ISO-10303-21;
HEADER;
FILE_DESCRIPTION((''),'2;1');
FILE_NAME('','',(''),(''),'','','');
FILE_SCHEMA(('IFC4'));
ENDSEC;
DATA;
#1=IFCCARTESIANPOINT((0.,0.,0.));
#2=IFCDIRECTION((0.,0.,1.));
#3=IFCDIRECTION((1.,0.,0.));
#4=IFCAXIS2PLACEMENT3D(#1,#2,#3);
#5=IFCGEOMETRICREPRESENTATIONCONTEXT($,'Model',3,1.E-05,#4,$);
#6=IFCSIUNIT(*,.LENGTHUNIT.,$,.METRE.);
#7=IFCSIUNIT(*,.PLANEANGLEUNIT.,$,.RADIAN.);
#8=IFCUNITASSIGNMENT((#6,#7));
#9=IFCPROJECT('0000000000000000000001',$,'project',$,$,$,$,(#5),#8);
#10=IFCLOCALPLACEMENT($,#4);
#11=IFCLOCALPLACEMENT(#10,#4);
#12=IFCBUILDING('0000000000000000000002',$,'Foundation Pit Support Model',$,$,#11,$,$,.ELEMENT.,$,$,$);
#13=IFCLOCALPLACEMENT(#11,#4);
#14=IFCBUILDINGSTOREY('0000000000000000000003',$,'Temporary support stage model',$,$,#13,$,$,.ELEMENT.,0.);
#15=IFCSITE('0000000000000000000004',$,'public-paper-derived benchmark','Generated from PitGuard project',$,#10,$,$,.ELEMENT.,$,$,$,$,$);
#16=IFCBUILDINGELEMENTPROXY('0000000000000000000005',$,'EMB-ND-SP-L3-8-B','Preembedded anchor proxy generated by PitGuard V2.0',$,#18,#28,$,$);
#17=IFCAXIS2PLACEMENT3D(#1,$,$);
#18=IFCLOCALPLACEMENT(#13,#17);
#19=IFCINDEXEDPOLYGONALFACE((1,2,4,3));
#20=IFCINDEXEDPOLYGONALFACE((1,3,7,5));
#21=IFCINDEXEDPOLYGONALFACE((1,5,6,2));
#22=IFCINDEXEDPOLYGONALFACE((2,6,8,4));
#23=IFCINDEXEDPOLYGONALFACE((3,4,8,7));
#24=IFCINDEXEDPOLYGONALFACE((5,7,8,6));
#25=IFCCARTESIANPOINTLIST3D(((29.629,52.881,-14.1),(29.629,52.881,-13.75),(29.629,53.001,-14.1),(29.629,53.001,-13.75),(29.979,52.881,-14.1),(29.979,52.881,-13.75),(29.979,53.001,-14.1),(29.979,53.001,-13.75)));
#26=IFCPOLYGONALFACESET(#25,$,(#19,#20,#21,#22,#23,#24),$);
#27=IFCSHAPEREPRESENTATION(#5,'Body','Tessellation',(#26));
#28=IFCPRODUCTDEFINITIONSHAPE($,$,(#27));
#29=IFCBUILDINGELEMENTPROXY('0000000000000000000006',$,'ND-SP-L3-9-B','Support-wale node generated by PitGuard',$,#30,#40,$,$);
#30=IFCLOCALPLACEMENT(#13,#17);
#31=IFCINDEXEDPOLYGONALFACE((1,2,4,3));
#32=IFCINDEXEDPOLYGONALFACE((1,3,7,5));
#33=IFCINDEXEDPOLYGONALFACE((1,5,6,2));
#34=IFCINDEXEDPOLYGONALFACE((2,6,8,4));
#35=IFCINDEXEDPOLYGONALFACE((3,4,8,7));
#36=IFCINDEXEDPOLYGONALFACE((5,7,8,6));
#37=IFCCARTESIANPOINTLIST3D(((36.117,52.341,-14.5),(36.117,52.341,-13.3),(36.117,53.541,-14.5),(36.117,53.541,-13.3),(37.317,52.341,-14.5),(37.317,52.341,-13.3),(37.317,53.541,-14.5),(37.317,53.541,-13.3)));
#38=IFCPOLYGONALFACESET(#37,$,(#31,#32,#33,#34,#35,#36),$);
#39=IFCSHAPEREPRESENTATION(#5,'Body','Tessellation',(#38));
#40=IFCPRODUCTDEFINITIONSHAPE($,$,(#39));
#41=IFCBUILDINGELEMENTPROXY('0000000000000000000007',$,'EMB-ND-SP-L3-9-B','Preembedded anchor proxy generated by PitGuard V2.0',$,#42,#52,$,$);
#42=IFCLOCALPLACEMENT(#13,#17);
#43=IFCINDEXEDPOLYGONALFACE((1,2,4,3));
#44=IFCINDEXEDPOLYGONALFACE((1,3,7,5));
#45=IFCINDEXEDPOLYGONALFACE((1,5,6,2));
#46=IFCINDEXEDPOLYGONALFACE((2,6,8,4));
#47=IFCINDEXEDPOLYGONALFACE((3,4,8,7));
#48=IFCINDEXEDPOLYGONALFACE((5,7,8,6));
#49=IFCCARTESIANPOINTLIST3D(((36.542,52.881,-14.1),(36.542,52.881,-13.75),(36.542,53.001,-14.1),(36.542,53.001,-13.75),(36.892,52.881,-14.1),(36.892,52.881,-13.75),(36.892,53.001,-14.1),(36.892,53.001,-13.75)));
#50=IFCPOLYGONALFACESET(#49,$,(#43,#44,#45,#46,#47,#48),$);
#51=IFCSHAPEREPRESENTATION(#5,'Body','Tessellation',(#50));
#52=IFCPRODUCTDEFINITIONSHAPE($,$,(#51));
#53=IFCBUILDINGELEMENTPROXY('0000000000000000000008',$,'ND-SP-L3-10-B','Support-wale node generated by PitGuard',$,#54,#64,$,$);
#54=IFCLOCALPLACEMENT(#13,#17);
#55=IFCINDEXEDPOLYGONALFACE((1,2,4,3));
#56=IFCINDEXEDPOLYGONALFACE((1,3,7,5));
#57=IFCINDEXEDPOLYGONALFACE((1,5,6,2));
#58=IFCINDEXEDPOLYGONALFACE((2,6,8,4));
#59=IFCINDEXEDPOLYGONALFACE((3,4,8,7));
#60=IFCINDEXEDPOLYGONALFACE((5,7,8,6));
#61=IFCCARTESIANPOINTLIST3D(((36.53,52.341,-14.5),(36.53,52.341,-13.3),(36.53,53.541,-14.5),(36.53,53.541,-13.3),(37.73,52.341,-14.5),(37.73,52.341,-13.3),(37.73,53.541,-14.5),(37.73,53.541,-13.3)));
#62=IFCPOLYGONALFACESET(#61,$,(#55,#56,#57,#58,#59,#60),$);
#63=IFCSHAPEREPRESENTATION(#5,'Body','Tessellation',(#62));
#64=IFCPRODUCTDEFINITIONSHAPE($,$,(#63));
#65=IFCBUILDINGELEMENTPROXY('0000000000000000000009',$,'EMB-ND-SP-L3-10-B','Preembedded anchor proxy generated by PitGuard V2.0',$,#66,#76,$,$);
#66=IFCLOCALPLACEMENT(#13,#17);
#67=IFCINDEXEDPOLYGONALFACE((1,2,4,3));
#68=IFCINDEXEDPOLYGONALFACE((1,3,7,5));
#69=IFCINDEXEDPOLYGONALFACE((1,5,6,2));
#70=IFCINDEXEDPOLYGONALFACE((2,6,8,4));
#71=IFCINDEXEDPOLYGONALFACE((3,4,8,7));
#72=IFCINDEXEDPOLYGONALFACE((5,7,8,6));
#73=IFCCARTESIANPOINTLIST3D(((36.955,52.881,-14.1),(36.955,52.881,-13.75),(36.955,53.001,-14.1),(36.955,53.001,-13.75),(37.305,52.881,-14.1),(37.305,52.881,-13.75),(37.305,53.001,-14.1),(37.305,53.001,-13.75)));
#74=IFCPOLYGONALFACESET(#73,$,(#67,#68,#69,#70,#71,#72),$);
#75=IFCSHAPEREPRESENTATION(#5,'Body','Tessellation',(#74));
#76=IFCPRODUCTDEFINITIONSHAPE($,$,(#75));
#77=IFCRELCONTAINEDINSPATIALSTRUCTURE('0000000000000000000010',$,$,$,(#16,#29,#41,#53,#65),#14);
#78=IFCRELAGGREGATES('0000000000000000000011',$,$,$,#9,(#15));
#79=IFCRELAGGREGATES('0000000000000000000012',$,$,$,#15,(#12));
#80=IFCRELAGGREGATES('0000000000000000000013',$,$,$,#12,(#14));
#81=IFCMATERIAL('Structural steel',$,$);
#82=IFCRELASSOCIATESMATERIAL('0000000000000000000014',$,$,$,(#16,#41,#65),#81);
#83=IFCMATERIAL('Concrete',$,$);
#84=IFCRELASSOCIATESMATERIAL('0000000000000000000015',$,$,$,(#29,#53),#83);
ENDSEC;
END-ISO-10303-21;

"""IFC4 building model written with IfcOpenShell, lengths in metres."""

from ifc_helpers import new_model, si_unit, frame, origin_with_axes, origin_2d, place, context, project, spatial, rectangle, extrude, material, element, save


model = new_model("IFC4")

# Units and contexts
model_context = context("Model", 3, precision=1e-05, world=origin_with_axes())
ifc_project = project(units=[si_unit("LENGTHUNIT", "METRE"), si_unit("PLANEANGLEUNIT", "RADIAN")], contexts=[model_context])

# Site, building, storey
site_placement = place(None, origin_with_axes())
site = spatial("IfcSite", under=ifc_project, at=site_placement, Name="public-paper-derived benchmark", Description="Generated from PitGuard project", CompositionType="ELEMENT")
building_placement = place(site_placement, origin_with_axes())
building = spatial("IfcBuilding", under=site, at=building_placement, Name="Foundation Pit Support Model", CompositionType="ELEMENT")
storey_placement = place(building_placement, origin_with_axes())
storey = spatial("IfcBuildingStorey", under=building, at=storey_placement, Name="Temporary support stage model", CompositionType="ELEMENT", Elevation=0.0)

# Shared definitions
ifc_material_1 = material(Name="Structural steel")

# Shared definitions
ifc_material_2 = material(Name="Concrete")

# Building element proxies
proxy_1_placement = place(storey_placement, frame((29.804, 52.941, -14.1), z_axis=(0.0, 0.0, 1.0), x_axis=(1.0, 0.0, 0.0)))
element("IfcBuildingElementProxy", 1, at=proxy_1_placement, inside=storey, material=ifc_material_1, Name="EMB-ND-SP-L3-8-B", Description="Preembedded anchor proxy generated by PitGuard V2.0", context=model_context, shape_type="SweptSolid", body=[
    extrude(rectangle(XDim=0.35, YDim=0.12, at=origin_2d()), origin_with_axes(), (0.0, 0.0, 1.0), 0.35),
])
proxy_2_placement = place(storey_placement, frame((36.717, 52.941, -14.5), z_axis=(0.0, 0.0, 1.0), x_axis=(1.0, 0.0, 0.0)))
element("IfcBuildingElementProxy", 2, at=proxy_2_placement, inside=storey, material=ifc_material_2, Name="ND-SP-L3-9-B", Description="Support-wale node generated by PitGuard", context=model_context, shape_type="SweptSolid", body=[
    extrude(rectangle(XDim=1.2, YDim=1.2, at=origin_2d()), origin_with_axes(), (0.0, 0.0, 1.0), 1.2),
])
proxy_3_placement = place(storey_placement, frame((36.717, 52.941, -14.1), z_axis=(0.0, 0.0, 1.0), x_axis=(1.0, 0.0, 0.0)))
element("IfcBuildingElementProxy", 3, at=proxy_3_placement, inside=storey, material=ifc_material_1, Name="EMB-ND-SP-L3-9-B", Description="Preembedded anchor proxy generated by PitGuard V2.0", context=model_context, shape_type="SweptSolid", body=[
    extrude(rectangle(XDim=0.35, YDim=0.12, at=origin_2d()), origin_with_axes(), (0.0, 0.0, 1.0), 0.35),
])
proxy_4_placement = place(storey_placement, frame((37.13, 52.941, -14.5), z_axis=(0.0, 0.0, 1.0), x_axis=(1.0, 0.0, 0.0)))
element("IfcBuildingElementProxy", 4, at=proxy_4_placement, inside=storey, material=ifc_material_2, Name="ND-SP-L3-10-B", Description="Support-wale node generated by PitGuard", context=model_context, shape_type="SweptSolid", body=[
    extrude(rectangle(XDim=1.2, YDim=1.2, at=origin_2d()), origin_with_axes(), (0.0, 0.0, 1.0), 1.2),
])
proxy_5_placement = place(storey_placement, frame((37.13, 52.941, -14.1), z_axis=(0.0, 0.0, 1.0), x_axis=(1.0, 0.0, 0.0)))
element("IfcBuildingElementProxy", 5, at=proxy_5_placement, inside=storey, material=ifc_material_1, Name="EMB-ND-SP-L3-10-B", Description="Preembedded anchor proxy generated by PitGuard V2.0", context=model_context, shape_type="SweptSolid", body=[
    extrude(rectangle(XDim=0.35, YDim=0.12, at=origin_2d()), origin_with_axes(), (0.0, 0.0, 1.0), 0.35),
])

save(model, "model.ifc")
